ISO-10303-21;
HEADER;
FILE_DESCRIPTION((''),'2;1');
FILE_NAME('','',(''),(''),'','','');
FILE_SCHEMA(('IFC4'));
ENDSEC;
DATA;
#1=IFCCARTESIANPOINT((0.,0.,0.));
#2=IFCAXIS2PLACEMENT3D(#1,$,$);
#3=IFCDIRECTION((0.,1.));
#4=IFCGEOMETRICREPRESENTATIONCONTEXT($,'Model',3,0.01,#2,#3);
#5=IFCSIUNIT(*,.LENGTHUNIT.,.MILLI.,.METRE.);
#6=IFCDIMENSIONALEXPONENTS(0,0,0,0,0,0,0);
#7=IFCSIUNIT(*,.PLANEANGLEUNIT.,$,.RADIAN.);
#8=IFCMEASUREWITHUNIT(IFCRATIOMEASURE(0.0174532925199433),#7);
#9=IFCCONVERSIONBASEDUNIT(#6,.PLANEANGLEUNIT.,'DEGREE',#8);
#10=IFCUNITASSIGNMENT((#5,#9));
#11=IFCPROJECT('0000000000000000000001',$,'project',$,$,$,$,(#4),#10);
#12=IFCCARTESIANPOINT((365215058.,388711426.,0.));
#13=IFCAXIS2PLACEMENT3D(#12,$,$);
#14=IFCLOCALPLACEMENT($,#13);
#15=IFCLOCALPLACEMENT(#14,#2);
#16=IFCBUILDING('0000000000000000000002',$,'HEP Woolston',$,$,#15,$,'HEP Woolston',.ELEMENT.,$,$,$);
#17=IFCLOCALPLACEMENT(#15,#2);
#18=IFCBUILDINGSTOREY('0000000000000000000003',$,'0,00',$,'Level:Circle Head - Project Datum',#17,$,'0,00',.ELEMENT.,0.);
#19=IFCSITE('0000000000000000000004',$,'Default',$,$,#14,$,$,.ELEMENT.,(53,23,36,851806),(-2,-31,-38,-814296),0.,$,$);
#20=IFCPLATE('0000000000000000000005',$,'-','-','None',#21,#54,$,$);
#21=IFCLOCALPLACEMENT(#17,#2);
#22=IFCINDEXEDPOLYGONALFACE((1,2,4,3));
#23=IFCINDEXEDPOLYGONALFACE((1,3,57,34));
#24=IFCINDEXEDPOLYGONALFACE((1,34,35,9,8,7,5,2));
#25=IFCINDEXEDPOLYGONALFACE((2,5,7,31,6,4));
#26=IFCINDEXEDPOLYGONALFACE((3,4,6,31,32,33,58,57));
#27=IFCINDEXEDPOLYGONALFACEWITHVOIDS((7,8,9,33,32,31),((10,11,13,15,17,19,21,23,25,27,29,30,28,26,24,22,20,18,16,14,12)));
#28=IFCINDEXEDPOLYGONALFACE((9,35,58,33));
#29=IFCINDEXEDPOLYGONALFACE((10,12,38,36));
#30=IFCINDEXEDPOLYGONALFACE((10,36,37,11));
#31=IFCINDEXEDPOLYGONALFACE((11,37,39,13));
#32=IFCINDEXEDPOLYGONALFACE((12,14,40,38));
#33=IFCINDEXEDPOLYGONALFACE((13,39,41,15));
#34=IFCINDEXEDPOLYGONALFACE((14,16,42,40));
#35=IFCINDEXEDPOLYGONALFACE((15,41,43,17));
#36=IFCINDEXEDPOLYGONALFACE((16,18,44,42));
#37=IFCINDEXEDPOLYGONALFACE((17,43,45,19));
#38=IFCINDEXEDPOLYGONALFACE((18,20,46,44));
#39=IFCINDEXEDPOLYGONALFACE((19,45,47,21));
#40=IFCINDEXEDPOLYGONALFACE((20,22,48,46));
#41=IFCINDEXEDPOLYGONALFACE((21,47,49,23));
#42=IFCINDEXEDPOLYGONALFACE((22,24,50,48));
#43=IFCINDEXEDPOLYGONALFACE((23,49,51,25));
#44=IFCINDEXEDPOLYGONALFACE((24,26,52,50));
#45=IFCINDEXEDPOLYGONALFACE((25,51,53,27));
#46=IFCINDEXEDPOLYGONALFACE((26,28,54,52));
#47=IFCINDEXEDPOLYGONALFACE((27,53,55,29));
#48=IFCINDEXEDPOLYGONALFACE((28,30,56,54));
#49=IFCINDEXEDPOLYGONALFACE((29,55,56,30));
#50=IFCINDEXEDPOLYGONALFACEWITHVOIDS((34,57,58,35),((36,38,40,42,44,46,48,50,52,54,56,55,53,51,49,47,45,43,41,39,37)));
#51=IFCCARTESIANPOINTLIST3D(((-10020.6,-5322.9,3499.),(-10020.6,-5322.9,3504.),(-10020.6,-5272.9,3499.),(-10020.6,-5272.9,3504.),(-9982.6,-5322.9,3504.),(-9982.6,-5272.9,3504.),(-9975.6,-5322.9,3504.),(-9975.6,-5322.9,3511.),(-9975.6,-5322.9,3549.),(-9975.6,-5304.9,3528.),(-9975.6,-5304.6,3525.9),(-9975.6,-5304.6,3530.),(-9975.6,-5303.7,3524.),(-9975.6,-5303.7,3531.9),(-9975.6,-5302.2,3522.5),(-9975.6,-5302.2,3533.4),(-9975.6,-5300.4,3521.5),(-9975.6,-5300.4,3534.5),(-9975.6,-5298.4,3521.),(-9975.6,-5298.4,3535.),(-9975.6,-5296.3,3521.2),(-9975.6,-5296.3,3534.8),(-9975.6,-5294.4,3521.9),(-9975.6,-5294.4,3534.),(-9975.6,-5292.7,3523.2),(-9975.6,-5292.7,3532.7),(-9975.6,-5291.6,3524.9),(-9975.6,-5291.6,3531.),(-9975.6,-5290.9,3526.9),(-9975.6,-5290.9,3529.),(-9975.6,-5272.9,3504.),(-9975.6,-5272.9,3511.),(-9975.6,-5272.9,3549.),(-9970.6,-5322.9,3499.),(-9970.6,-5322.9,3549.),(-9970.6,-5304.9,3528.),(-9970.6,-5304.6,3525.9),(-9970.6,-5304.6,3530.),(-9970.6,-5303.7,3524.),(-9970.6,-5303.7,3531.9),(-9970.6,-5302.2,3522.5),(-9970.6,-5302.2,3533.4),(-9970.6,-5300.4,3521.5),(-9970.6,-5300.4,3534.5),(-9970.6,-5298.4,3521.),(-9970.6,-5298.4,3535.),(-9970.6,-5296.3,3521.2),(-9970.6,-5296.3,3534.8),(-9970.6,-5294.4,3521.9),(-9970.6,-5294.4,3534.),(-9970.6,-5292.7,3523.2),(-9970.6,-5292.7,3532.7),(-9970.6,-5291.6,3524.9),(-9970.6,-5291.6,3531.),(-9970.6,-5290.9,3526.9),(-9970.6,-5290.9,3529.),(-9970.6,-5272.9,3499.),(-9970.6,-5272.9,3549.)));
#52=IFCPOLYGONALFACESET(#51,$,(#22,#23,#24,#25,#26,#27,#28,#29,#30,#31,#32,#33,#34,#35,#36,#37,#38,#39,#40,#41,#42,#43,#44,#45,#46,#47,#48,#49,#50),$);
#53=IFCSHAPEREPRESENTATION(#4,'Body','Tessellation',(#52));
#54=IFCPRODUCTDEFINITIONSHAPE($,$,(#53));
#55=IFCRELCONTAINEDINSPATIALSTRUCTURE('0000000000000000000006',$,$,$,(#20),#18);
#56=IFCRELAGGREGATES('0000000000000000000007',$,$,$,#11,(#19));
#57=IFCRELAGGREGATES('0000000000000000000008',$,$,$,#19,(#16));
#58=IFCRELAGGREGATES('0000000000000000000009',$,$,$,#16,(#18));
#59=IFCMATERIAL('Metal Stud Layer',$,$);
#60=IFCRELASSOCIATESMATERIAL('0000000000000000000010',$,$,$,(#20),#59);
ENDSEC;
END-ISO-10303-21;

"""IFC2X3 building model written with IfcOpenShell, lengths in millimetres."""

from ifc_helpers import new_model, entity, si_unit, converted_unit, point, direction, frame, frame_2d, origin, origin_with_axes, origin_2d_with_axis, place, context, project, spatial, polyline, circle_curve, line_curve, trimmed, segment, composite_curve, circle, outline, extrude, material, element, save


model = new_model("IFC2X3")

# Units and contexts
model_context = context("Model", 3, precision=0.01, world=origin(), true_north=direction((0.0, 1.0)))
ifc_project = project(units=[si_unit("LENGTHUNIT", "METRE", prefix="MILLI"), converted_unit("PLANEANGLEUNIT", "DEGREE", entity("IfcRatioMeasure", 0.0174532925199433), si_unit("PLANEANGLEUNIT", "RADIAN"), dimensions=[0, 0, 0, 0, 0, 0, 0])], contexts=[model_context])

# Site, building, storey
site_placement = place(None, frame((365215058.0, 388711426.0, 0.0)))
site = spatial("IfcSite", under=ifc_project, at=site_placement, Name="Default", CompositionType="ELEMENT", RefLatitude=(53, 23, 36, 851806), RefLongitude=(-2, -31, -38, -814296), RefElevation=0.0)
building_placement = place(site_placement, origin())
building = spatial("IfcBuilding", under=site, at=building_placement, Name="HEP Woolston", LongName="HEP Woolston", CompositionType="ELEMENT")
storey_placement = place(building_placement, origin())
storey = spatial("IfcBuildingStorey", under=building, at=storey_placement, Name="0,00", ObjectType="Level:Circle Head - Project Datum", LongName="0,00", CompositionType="ELEMENT", Elevation=0.0)

# Plate, openings
ifc_material_1 = material(Name="Metal Stud Layer")
plate_1_placement = place(storey_placement, frame((-9970.6, -5322.9, 3499.0), z_axis=(0.0, 1.0, 0.0), x_axis=(-1.0, 0.0, 0.0)))
plate_1 = element("IfcPlate", 1, at=plate_1_placement, inside=storey, material=ifc_material_1, Name="-", Description="-", ObjectType="None", context=model_context, shape_type="SweptSolid", body=[
    extrude(outline(polyline([(0.0, 0.0), (50.0, 0.0), (50.0, 5.0), (5.0, 5.0), (5.0, 50.0), (0.0, 50.0), (0.0, 0.0)])), origin_with_axes(), (0.0, 0.0, 1.0), 50.0),
])
opening_1_placement = place(plate_1_placement, frame((0.0, 0.0, 0.0), z_axis=(0.0, 0.0, 1.0), x_axis=(1.0, 0.0, 0.0)))
element("IfcOpeningElement", 2, at=opening_1_placement, cuts=plate_1, ObjectType="Opening", context=model_context, shape_type="SweptSolid", body=[
    extrude(outline(composite_curve([segment(trimmed(line_curve((50.0, 5.0), (1.0, 0.0), 3.532613), [point((50.0, 5.0))], [point((46.5, 5.0))], True, "CARTESIAN"), True, "CONTINUOUS"), segment(trimmed(circle_curve(frame_2d((46.5, 1.5), x_axis=(-1.0, 0.0)), 3.5), [point((46.5, 5.0))], [point((50.0, 1.5))], False, "CARTESIAN"), True, "CONTINUOUS"), segment(trimmed(line_curve((50.0, 1.5), (0.0, -1.0), 3.532613), [point((50.0, 1.5))], [point((50.0, 5.0))], True, "CARTESIAN"), True, "CONTINUOUS")], self_intersect="UNKNOWN")), origin(), (0.0, 0.0, 1.0), 50.0),
])
opening_2_placement = place(plate_1_placement, origin_with_axes())
element("IfcOpeningElement", 3, at=opening_2_placement, cuts=plate_1, ObjectType="Opening", context=model_context, shape_type="SweptSolid", body=[
    extrude(outline(composite_curve([segment(trimmed(line_curve((5.0, 5.0), (0.0, -1.0), 7.046301), [point((5.0, 5.0))], [point((5.0, 12.0))], False, "CARTESIAN"), True, "CONTINUOUS"), segment(trimmed(circle_curve(frame_2d((12.0, 12.0), x_axis=(1.0, 0.0)), 7.0), [point((5.0, 12.0))], [point((12.0, 5.0))], True, "CARTESIAN"), True, "CONTINUOUS"), segment(trimmed(line_curve((12.0, 5.0), (1.0, 0.0), 7.046301), [point((12.0, 5.0))], [point((5.0, 5.0))], False, "CARTESIAN"), True, "CONTINUOUS")], self_intersect="UNKNOWN")), origin(), (0.0, 0.0, 1.0), 50.0),
])
opening_3_placement = place(plate_1_placement, frame((0.0, 0.0, 0.0), z_axis=(0.0, 0.0, 1.0), x_axis=(1.0, 0.0, 0.0)))
element("IfcOpeningElement", 4, at=opening_3_placement, cuts=plate_1, ObjectType="Opening", context=model_context, shape_type="SweptSolid", body=[
    extrude(outline(composite_curve([segment(trimmed(line_curve((5.0, 50.0), (1.0, 0.0), 3.4874), [point((5.0, 50.0))], [point((1.5, 50.0))], True, "CARTESIAN"), True, "CONTINUOUS"), segment(trimmed(circle_curve(frame_2d((1.5, 46.5), x_axis=(-1.0, 0.0)), 3.5), [point((1.5, 50.0))], [point((5.0, 46.5))], False, "CARTESIAN"), True, "CONTINUOUS"), segment(trimmed(line_curve((5.0, 46.5), (0.0, -1.0), 3.4874), [point((5.0, 46.5))], [point((5.0, 50.0))], True, "CARTESIAN"), True, "CONTINUOUS")], self_intersect="UNKNOWN")), origin(), (0.0, 0.0, 1.0), 50.0),
])
opening_4_placement = place(plate_1_placement, frame((-0.5, 29.0, 25.0), z_axis=(1.0, 0.0, 0.0), x_axis=(0.0, 0.0, -1.0)))
element("IfcOpeningElement", 5, at=opening_4_placement, cuts=plate_1, ObjectType="Opening", context=model_context, shape_type="SweptSolid", body=[
    extrude(circle(Radius=7.0, at=origin_2d_with_axis()), origin(), (0.0, 0.0, 1.0), 6.0),
])

save(model, "model.ifc")
